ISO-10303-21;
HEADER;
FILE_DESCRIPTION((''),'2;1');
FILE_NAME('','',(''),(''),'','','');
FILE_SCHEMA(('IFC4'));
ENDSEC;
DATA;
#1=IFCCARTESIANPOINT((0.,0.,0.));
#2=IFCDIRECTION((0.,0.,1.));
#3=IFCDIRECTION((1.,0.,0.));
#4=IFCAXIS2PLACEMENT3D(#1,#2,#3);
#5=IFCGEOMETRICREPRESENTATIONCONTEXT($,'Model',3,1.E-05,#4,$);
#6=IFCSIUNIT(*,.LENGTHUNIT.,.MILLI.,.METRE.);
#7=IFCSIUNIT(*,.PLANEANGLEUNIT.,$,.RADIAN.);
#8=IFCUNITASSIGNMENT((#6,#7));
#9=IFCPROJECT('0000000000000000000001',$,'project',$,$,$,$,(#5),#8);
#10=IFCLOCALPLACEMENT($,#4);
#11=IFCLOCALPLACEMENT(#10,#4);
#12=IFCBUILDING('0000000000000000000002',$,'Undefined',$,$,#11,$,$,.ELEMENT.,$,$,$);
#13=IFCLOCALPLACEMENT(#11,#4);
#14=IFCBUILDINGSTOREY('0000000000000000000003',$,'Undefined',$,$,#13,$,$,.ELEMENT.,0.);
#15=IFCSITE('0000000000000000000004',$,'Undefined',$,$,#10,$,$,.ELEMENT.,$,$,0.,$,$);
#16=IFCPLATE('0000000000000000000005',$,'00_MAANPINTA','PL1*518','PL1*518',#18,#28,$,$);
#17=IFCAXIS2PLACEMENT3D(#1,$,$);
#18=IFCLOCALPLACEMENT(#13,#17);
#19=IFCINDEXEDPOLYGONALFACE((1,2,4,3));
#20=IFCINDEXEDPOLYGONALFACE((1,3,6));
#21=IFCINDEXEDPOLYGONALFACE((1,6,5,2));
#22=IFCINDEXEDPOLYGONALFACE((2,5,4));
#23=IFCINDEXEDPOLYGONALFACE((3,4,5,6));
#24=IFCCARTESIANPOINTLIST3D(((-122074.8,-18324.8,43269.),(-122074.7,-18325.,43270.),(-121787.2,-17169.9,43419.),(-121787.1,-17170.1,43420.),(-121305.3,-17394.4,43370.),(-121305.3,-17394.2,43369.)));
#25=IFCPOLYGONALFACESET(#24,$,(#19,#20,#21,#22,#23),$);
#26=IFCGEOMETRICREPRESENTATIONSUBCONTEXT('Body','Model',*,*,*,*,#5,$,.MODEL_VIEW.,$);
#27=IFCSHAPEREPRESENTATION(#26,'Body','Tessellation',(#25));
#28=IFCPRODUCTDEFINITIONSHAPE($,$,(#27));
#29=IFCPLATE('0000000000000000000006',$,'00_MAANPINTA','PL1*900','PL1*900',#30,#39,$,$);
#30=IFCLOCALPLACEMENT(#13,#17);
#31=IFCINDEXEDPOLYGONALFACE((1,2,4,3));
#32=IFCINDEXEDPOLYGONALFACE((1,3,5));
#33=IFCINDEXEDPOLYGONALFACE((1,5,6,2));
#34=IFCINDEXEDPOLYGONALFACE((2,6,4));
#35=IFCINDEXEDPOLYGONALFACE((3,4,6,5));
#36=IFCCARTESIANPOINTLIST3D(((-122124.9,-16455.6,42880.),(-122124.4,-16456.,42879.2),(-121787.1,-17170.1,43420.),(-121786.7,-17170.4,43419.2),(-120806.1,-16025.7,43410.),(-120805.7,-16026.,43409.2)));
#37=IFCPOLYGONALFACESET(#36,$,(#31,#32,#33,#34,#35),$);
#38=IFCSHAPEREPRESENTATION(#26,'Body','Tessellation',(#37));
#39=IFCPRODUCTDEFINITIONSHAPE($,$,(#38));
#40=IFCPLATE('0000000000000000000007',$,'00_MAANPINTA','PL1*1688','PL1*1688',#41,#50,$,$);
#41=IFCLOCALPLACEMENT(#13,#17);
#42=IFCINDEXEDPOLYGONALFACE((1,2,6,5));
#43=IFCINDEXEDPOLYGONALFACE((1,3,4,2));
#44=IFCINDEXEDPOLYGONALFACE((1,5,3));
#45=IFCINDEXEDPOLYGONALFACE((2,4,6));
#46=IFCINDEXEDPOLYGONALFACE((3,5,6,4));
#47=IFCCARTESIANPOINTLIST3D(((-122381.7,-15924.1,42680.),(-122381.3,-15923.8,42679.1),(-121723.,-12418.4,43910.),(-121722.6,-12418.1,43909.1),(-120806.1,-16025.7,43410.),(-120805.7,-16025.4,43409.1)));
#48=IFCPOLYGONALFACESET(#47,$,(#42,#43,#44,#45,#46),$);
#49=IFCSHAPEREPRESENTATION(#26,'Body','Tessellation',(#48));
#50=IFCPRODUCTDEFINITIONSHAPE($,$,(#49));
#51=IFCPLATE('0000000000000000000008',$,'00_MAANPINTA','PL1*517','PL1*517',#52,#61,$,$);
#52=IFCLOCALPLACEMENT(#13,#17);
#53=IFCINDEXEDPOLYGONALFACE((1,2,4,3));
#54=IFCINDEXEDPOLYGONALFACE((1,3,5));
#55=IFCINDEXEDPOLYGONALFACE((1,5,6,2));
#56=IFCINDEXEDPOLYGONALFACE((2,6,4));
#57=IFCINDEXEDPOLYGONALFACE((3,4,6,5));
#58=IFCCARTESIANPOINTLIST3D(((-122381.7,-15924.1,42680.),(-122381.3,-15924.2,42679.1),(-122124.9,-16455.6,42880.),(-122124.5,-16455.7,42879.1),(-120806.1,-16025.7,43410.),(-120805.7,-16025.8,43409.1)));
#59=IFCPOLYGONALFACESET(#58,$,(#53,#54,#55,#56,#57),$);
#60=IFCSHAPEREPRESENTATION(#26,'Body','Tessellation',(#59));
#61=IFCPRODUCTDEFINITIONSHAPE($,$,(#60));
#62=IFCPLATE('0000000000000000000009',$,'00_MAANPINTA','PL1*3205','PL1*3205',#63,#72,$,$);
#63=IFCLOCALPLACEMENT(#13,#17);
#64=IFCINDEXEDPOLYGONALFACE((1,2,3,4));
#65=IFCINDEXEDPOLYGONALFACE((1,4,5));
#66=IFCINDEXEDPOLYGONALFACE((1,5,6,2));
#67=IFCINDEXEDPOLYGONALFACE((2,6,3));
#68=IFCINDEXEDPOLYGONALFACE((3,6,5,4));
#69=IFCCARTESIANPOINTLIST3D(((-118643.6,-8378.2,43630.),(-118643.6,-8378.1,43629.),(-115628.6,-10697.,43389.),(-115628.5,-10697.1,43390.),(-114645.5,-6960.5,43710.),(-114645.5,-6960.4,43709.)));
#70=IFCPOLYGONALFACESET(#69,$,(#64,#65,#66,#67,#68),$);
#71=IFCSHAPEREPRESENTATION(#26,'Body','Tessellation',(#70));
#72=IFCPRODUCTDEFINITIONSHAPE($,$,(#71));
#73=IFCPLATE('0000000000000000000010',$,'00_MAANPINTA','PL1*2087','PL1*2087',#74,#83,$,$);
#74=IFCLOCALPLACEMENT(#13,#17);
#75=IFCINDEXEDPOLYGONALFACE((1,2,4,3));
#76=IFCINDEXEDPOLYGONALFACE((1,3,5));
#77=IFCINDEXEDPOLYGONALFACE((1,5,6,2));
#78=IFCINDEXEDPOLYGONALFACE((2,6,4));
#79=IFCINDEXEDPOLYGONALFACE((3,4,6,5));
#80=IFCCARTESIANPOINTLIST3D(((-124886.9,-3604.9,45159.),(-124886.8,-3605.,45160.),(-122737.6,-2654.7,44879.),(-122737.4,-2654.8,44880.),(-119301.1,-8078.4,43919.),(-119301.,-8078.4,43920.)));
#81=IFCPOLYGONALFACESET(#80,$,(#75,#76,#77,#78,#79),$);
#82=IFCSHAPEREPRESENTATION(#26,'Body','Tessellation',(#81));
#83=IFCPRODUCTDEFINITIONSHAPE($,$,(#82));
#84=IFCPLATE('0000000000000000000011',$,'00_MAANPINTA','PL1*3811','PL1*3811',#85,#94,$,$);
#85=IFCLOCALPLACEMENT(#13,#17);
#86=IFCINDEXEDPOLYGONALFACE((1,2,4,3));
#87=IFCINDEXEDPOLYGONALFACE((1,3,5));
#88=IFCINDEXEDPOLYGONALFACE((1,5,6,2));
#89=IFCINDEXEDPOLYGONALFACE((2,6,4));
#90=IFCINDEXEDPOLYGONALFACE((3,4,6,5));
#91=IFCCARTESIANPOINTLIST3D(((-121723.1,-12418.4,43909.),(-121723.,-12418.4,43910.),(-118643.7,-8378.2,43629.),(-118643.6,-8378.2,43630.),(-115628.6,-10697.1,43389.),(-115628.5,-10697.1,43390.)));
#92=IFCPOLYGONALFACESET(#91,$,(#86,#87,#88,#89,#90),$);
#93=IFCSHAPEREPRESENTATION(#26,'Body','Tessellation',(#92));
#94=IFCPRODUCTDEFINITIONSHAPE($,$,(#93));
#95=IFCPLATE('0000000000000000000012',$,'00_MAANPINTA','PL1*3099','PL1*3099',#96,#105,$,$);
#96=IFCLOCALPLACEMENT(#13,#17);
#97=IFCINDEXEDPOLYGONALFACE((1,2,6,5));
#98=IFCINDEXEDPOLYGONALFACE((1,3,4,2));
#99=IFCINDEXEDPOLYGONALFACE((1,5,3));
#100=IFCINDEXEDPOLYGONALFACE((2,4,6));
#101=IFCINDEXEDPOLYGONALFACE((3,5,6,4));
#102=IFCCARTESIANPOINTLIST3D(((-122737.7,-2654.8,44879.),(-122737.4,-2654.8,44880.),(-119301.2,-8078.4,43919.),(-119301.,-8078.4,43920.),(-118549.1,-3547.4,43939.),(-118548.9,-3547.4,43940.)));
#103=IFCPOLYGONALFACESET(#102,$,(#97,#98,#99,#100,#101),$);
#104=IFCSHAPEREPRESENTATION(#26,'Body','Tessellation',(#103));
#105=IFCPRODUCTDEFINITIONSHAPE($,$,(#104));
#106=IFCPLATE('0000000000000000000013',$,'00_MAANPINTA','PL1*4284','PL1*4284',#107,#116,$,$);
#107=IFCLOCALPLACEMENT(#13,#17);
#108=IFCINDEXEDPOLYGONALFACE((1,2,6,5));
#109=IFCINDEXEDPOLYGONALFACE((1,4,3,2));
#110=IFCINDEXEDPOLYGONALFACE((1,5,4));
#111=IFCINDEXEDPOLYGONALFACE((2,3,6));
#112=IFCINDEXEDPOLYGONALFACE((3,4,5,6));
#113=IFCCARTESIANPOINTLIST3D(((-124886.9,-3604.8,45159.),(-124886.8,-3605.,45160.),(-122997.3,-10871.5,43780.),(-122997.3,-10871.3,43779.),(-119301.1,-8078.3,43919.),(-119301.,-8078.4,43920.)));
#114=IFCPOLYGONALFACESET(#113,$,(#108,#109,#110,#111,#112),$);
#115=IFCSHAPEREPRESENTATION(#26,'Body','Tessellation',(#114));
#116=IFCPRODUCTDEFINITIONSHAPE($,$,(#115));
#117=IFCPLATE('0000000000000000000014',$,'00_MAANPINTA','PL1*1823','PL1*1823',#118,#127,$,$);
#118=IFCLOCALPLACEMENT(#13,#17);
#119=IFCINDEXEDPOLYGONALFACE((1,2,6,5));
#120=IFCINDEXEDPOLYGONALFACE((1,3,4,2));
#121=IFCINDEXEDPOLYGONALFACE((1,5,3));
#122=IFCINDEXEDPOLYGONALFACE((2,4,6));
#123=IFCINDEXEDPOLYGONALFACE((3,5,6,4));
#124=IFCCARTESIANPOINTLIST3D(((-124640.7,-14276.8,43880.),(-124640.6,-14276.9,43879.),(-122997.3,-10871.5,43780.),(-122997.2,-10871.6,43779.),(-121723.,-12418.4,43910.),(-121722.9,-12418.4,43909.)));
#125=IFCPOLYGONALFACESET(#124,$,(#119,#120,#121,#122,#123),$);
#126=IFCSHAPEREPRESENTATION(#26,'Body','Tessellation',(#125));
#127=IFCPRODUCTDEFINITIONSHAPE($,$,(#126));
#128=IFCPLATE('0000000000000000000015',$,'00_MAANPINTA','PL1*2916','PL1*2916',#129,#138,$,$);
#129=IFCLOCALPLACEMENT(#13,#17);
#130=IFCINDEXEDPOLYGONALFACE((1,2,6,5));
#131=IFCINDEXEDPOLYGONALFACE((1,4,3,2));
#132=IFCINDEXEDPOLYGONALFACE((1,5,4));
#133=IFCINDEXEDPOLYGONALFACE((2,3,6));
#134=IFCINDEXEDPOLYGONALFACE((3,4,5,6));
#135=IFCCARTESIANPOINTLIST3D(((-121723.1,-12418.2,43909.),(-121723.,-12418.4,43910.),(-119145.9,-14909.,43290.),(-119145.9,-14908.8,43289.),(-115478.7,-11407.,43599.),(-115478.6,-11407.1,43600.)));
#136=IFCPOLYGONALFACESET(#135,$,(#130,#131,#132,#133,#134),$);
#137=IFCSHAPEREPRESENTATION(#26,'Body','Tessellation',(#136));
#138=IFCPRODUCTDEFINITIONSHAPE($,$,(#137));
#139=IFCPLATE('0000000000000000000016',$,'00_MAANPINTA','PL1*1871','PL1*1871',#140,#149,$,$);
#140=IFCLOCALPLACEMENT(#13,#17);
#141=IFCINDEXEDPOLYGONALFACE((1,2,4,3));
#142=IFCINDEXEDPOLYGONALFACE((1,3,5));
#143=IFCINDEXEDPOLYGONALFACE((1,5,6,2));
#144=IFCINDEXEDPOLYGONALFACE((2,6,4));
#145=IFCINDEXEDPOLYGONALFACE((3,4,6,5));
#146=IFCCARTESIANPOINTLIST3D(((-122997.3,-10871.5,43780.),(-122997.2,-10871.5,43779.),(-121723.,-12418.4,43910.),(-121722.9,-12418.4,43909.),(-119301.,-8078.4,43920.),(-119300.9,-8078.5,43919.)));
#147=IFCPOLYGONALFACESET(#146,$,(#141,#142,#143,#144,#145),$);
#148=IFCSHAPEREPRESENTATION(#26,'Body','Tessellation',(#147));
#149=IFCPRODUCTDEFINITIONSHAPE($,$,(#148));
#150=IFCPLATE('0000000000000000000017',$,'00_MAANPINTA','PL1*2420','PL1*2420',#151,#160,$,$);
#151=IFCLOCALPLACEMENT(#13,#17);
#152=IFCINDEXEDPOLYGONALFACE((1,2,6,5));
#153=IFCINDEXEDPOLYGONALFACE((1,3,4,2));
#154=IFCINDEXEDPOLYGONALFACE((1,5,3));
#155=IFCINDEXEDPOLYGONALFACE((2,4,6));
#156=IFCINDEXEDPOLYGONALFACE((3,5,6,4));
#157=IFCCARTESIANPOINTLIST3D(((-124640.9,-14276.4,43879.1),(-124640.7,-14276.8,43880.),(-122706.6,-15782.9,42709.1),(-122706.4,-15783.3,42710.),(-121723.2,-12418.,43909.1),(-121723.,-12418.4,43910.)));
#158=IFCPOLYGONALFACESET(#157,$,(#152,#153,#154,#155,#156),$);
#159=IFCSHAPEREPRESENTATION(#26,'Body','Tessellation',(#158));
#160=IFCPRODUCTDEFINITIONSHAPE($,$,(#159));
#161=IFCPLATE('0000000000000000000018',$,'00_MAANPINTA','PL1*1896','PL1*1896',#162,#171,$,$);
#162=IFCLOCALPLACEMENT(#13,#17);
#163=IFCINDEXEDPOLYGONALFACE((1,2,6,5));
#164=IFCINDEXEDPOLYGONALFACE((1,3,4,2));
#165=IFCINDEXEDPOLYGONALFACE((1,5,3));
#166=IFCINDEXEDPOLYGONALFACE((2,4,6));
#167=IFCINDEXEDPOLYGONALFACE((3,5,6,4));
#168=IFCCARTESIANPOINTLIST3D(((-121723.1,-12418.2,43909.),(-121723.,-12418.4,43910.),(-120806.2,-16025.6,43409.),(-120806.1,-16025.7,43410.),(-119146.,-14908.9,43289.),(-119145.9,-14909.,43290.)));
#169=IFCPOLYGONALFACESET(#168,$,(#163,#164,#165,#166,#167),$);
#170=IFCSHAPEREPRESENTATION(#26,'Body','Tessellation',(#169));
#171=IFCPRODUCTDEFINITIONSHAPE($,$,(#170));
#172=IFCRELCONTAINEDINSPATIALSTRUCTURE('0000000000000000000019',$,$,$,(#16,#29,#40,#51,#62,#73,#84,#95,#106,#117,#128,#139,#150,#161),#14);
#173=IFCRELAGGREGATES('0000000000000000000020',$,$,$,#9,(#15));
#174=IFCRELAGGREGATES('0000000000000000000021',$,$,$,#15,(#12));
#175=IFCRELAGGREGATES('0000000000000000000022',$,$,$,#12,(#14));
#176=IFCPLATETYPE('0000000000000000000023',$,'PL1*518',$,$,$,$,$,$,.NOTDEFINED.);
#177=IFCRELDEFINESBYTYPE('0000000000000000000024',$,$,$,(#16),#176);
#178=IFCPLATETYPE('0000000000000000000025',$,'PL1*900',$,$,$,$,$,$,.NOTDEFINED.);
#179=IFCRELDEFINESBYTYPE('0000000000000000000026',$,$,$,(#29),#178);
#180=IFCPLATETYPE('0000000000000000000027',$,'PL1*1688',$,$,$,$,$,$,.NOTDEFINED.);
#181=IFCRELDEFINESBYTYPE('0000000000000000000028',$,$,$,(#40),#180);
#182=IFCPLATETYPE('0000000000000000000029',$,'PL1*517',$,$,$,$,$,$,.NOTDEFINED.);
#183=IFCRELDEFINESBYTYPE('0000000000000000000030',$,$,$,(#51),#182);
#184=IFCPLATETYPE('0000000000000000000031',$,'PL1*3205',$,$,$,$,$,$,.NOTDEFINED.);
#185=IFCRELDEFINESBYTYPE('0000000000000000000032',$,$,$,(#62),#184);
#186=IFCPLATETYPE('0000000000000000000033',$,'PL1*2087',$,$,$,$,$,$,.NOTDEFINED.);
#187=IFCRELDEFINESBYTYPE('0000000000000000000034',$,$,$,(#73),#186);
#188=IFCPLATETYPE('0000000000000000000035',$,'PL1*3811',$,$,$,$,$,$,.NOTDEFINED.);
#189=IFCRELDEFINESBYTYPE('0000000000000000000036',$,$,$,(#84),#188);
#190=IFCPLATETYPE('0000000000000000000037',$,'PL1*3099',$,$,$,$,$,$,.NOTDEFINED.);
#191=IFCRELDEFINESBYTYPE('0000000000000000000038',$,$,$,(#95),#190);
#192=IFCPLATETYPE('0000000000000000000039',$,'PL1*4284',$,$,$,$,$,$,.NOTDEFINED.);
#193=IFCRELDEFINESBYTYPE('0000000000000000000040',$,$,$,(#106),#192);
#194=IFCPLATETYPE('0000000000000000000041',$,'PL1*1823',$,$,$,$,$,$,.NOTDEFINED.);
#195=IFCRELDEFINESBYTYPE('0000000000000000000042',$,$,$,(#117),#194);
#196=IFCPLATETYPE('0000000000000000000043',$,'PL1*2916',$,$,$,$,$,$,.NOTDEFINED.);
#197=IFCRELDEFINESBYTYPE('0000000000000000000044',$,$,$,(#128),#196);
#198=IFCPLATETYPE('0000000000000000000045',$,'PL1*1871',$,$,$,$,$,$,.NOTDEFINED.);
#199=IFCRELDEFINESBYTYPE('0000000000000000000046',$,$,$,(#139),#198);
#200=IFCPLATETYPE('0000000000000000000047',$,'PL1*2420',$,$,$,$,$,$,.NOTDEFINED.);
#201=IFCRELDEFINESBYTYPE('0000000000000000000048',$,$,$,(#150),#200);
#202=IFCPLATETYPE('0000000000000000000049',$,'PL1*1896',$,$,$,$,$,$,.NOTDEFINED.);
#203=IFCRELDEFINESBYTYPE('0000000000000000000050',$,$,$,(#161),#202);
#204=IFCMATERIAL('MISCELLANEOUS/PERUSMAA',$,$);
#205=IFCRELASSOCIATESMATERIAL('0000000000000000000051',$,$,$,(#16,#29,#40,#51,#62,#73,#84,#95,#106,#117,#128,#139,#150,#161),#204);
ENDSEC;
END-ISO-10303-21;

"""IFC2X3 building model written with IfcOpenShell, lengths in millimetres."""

from ifc_helpers import new_model, si_unit, frame, origin_with_axes, place, context, subcontext, project, spatial, polyline, outline, extrude, material, type_object, element, save


model = new_model("IFC2X3")

# Units and contexts
model_context = context("Model", 3, precision=1e-05, world=origin_with_axes())
body_context = subcontext(model_context, "Body", "Model", "MODEL_VIEW")
ifc_project = project(units=[si_unit("LENGTHUNIT", "METRE", prefix="MILLI"), si_unit("PLANEANGLEUNIT", "RADIAN")], contexts=[model_context])

# Site, building, storey
site_placement = place(None, origin_with_axes())
site = spatial("IfcSite", under=ifc_project, at=site_placement, Name="Undefined", CompositionType="ELEMENT", RefElevation=0.0)
building_placement = place(site_placement, origin_with_axes())
building = spatial("IfcBuilding", under=site, at=building_placement, Name="Undefined", CompositionType="ELEMENT")
storey_placement = place(building_placement, origin_with_axes())
storey = spatial("IfcBuildingStorey", under=building, at=storey_placement, Name="Undefined", CompositionType="ELEMENT", Elevation=0.0)

# Plates
ifc_material = material(Name="MISCELLANEOUS/PERUSMAA")
plate_type_1 = type_object("IfcPlateType", Name="PL1*518", PredefinedType="NOTDEFINED")
plate_1_placement = place(storey_placement, frame((-121787.2, -17170.0, 43419.5), z_axis=(-0.038402, 0.138102, -0.989673), x_axis=(0.902588, -0.420195, -0.093659)))
element("IfcPlate", 1, at=plate_1_placement, inside=storey, type_object=plate_type_1, material=ifc_material, Name="00_MAANPINTA", Description="PL1*518", ObjectType="PL1*518", context=body_context, shape_type="SweptSolid", body=[
    extrude(outline(polyline([(0.0, 0.0), (533.9, 0.0), (239.8, 1175.4), (0.0, 0.0)])), frame((0.0, 0.0, -0.5), z_axis=(0.0, 0.0, 1.0), x_axis=(1.0, 0.0, 0.0)), (0.0, 0.0, 1.0), 1.0),
])
plate_type_2 = type_object("IfcPlateType", Name="PL1*900", PredefinedType="NOTDEFINED")
plate_2_placement = place(storey_placement, frame((-121786.9, -17170.3, 43419.6), z_axis=(0.450337, -0.393058, -0.801687), x_axis=(-0.35285, 0.746452, -0.564186)))
element("IfcPlate", 2, at=plate_2_placement, inside=storey, type_object=plate_type_2, material=ifc_material, Name="00_MAANPINTA", Description="PL1*900", ObjectType="PL1*900", context=body_context, shape_type="SweptSolid", body=[
    extrude(outline(polyline([(0.0, 0.0), (957.1, 0.0), (513.7, 1417.1), (0.0, 0.0)])), frame((0.0, 0.0, -0.5), z_axis=(0.0, 0.0, 1.0), x_axis=(1.0, 0.0, 0.0)), (0.0, 0.0, 1.0), 1.0),
])
plate_type_3 = type_object("IfcPlateType", Name="PL1*1688", PredefinedType="NOTDEFINED")
plate_3_placement = place(storey_placement, frame((-120805.9, -16025.5, 43409.6), z_axis=(0.42134, 0.228734, -0.877584), x_axis=(-0.905799, 0.058398, -0.419665)))
element("IfcPlate", 3, at=plate_3_placement, inside=storey, type_object=plate_type_3, material=ifc_material, Name="00_MAANPINTA", Description="PL1*1688", ObjectType="PL1*1688", context=body_context, shape_type="SweptSolid", body=[
    extrude(outline(polyline([(0.0, 0.0), (1739.5, 0.0), (831.3, 3662.3), (0.0, 0.0)])), frame((0.0, 0.0, -0.5), z_axis=(0.0, 0.0, 1.0), x_axis=(1.0, 0.0, 0.0)), (0.0, 0.0, 1.0), 1.0),
])
plate_type_4 = type_object("IfcPlateType", Name="PL1*517", PredefinedType="NOTDEFINED")
plate_4_placement = place(storey_placement, frame((-122124.7, -16455.7, 42879.5), z_axis=(0.408592, -0.141812, -0.901633), x_axis=(-0.41209, 0.852773, -0.320874)))
element("IfcPlate", 4, at=plate_4_placement, inside=storey, type_object=plate_type_4, material=ifc_material, Name="00_MAANPINTA", Description="PL1*517", ObjectType="PL1*517", context=body_context, shape_type="SweptSolid", body=[
    extrude(outline(polyline([(0.0, 0.0), (623.3, 0.0), (-346.9, 1443.8), (0.0, 0.0)])), frame((0.0, 0.0, -0.5), z_axis=(0.0, 0.0, 1.0), x_axis=(1.0, 0.0, 0.0)), (0.0, 0.0, 1.0), 1.0),
])
plate_type_5 = type_object("IfcPlateType", Name="PL1*3205", PredefinedType="NOTDEFINED")
plate_5_placement = place(storey_placement, frame((-115628.5, -10697.1, 43389.5), z_axis=(-0.011378, 0.088293, -0.99603), x_axis=(-0.791104, 0.608432, 0.062972)))
element("IfcPlate", 5, at=plate_5_placement, inside=storey, type_object=plate_type_5, material=ifc_material, Name="00_MAANPINTA", Description="PL1*3205", ObjectType="PL1*3205", context=body_context, shape_type="SweptSolid", body=[
    extrude(outline(polyline([(0.0, 0.0), (3811.2, 0.0), (1515.9, 3568.3), (0.0, 0.0)])), frame((0.0, 0.0, -0.5), z_axis=(0.0, 0.0, 1.0), x_axis=(1.0, 0.0, 0.0)), (0.0, 0.0, 1.0), 1.0),
])
plate_type_6 = type_object("IfcPlateType", Name="PL1*2087", PredefinedType="NOTDEFINED")
plate_6_placement = place(storey_placement, frame((-119301.1, -8078.4, 43919.5), z_axis=(-0.160352, 0.072639, -0.984383), x_axis=(-0.769082, 0.615926, 0.17073)))
element("IfcPlate", 6, at=plate_6_placement, inside=storey, type_object=plate_type_6, material=ifc_material, Name="00_MAANPINTA", Description="PL1*2087", ObjectType="PL1*2087", context=body_context, shape_type="SweptSolid", body=[
    extrude(outline(polyline([(0.0, 0.0), (7262.9, 0.0), (6147.4, 2087.2), (0.0, 0.0)])), frame((0.0, 0.0, -0.5), z_axis=(0.0, 0.0, 1.0), x_axis=(1.0, 0.0, 0.0)), (0.0, 0.0, 1.0), 1.0),
])
plate_type_7 = type_object("IfcPlateType", Name="PL1*3811", PredefinedType="NOTDEFINED")
plate_7_placement = place(storey_placement, frame((-118643.7, -8378.2, 43629.5), z_axis=(-0.083492, -0.005424, -0.996494), x_axis=(0.791104, -0.608432, -0.062972)))
element("IfcPlate", 7, at=plate_7_placement, inside=storey, type_object=plate_type_7, material=ifc_material, Name="00_MAANPINTA", Description="PL1*3811", ObjectType="PL1*3811", context=body_context, shape_type="SweptSolid", body=[
    extrude(outline(polyline([(0.0, 0.0), (3811.2, 0.0), (4.4, 5087.6), (0.0, 0.0)])), frame((0.0, 0.0, -0.5), z_axis=(0.0, 0.0, 1.0), x_axis=(1.0, 0.0, 0.0)), (0.0, 0.0, 1.0), 1.0),
])
plate_type_8 = type_object("IfcPlateType", Name="PL1*3099", PredefinedType="NOTDEFINED")
plate_8_placement = place(storey_placement, frame((-119301.1, -8078.4, 43919.5), z_axis=(-0.210822, 0.039307, -0.976734), x_axis=(-0.529334, 0.835427, 0.147873)))
element("IfcPlate", 8, at=plate_8_placement, inside=storey, type_object=plate_type_8, material=ifc_material, Name="00_MAANPINTA", Description="PL1*3099", ObjectType="PL1*3099", context=body_context, shape_type="SweptSolid", body=[
    extrude(outline(polyline([(0.0, 0.0), (6492.0, 0.0), (3390.2, 3098.9), (0.0, 0.0)])), frame((0.0, 0.0, -0.5), z_axis=(0.0, 0.0, 1.0), x_axis=(1.0, 0.0, 0.0)), (0.0, 0.0, 1.0), 1.0),
])
plate_type_9 = type_object("IfcPlateType", Name="PL1*4284", PredefinedType="NOTDEFINED")
plate_9_placement = place(storey_placement, frame((-119301.0, -8078.3, 43919.5), z_axis=(-0.08675, 0.164056, -0.982629), x_axis=(-0.797469, -0.602604, -0.030205)))
element("IfcPlate", 9, at=plate_9_placement, inside=storey, type_object=plate_type_9, material=ifc_material, Name="00_MAANPINTA", Description="PL1*4284", ObjectType="PL1*4284", context=body_context, shape_type="SweptSolid", body=[
    extrude(outline(polyline([(0.0, 0.0), (4635.0, 0.0), (1721.3, 7056.0), (0.0, 0.0)])), frame((0.0, 0.0, -0.5), z_axis=(0.0, 0.0, 1.0), x_axis=(1.0, 0.0, 0.0)), (0.0, 0.0, 1.0), 1.0),
])
plate_type_10 = type_object("IfcPlateType", Name="PL1*1823", PredefinedType="NOTDEFINED")
plate_10_placement = place(storey_placement, frame((-121723.0, -12418.4, 43909.5), z_axis=(0.041765, -0.04946, -0.997902), x_axis=(-0.843403, -0.537212, -0.008672)))
element("IfcPlate", 10, at=plate_10_placement, inside=storey, type_object=plate_type_10, material=ifc_material, Name="00_MAANPINTA", Description="PL1*1823", ObjectType="PL1*1823", context=body_context, shape_type="SweptSolid", body=[
    extrude(outline(polyline([(0.0, 0.0), (3459.4, 0.0), (244.9, 1993.3), (0.0, 0.0)])), frame((0.0, 0.0, -0.5), z_axis=(0.0, 0.0, 1.0), x_axis=(1.0, 0.0, 0.0)), (0.0, 0.0, 1.0), 1.0),
])
plate_type_11 = type_object("IfcPlateType", Name="PL1*2916", PredefinedType="NOTDEFINED")
plate_11_placement = place(storey_placement, frame((-119145.9, -14908.9, 43289.5), z_axis=(-0.075749, 0.166359, -0.983151), x_axis=(-0.708549, 0.684764, 0.17046)))
element("IfcPlate", 11, at=plate_11_placement, inside=storey, type_object=plate_type_11, material=ifc_material, Name="00_MAANPINTA", Description="PL1*2916", ObjectType="PL1*2916", context=body_context, shape_type="SweptSolid", body=[
    extrude(outline(polyline([(0.0, 0.0), (3637.2, 0.0), (-147.6, 5078.0), (0.0, 0.0)])), frame((0.0, 0.0, -0.5), z_axis=(0.0, 0.0, 1.0), x_axis=(1.0, 0.0, 0.0)), (0.0, 0.0, 1.0), 1.0),
])
plate_type_12 = type_object("IfcPlateType", Name="PL1*1871", PredefinedType="NOTDEFINED")
plate_12_placement = place(storey_placement, frame((-121723.0, -12418.4, 43909.5), z_axis=(0.062331, -0.032487, -0.997527), x_axis=(-0.634492, 0.770214, -0.06473)))
element("IfcPlate", 12, at=plate_12_placement, inside=storey, type_object=plate_type_12, material=ifc_material, Name="00_MAANPINTA", Description="PL1*1871", ObjectType="PL1*1871", context=body_context, shape_type="SweptSolid", body=[
    extrude(outline(polyline([(0.0, 0.0), (2008.3, 0.0), (1805.3, 4630.6), (0.0, 0.0)])), frame((0.0, 0.0, -0.5), z_axis=(0.0, 0.0, 1.0), x_axis=(1.0, 0.0, 0.0)), (0.0, 0.0, 1.0), 1.0),
])
plate_type_13 = type_object("IfcPlateType", Name="PL1*2420", PredefinedType="NOTDEFINED")
plate_13_placement = place(storey_placement, frame((-122706.5, -15783.1, 42709.6), z_axis=(-0.237409, 0.387106, -0.890947), x_axis=(-0.712031, 0.554551, 0.43068)))
element("IfcPlate", 13, at=plate_13_placement, inside=storey, type_object=plate_type_13, material=ifc_material, Name="00_MAANPINTA", Description="PL1*2420", ObjectType="PL1*2420", context=body_context, shape_type="SweptSolid", body=[
    extrude(outline(polyline([(0.0, 0.0), (2716.6, 0.0), (1682.7, 3301.3), (0.0, 0.0)])), frame((0.0, 0.0, -0.5), z_axis=(0.0, 0.0, 1.0), x_axis=(1.0, 0.0, 0.0)), (0.0, 0.0, 1.0), 1.0),
])
plate_type_14 = type_object("IfcPlateType", Name="PL1*1896", PredefinedType="NOTDEFINED")
plate_14_placement = place(storey_placement, frame((-121723.1, -12418.3, 43909.5), z_axis=(-0.139232, 0.10115, -0.98508), x_axis=(0.708549, -0.684764, -0.17046)))
element("IfcPlate", 14, at=plate_14_placement, inside=storey, type_object=plate_type_14, material=ifc_material, Name="00_MAANPINTA", Description="PL1*1896", ObjectType="PL1*1896", context=body_context, shape_type="SweptSolid", body=[
    extrude(outline(polyline([(0.0, 0.0), (3637.2, 0.0), (3205.0, 1957.3), (0.0, 0.0)])), frame((0.0, 0.0, -0.5), z_axis=(0.0, 0.0, 1.0), x_axis=(1.0, 0.0, 0.0)), (0.0, 0.0, 1.0), 1.0),
])

save(model, "model.ifc")
